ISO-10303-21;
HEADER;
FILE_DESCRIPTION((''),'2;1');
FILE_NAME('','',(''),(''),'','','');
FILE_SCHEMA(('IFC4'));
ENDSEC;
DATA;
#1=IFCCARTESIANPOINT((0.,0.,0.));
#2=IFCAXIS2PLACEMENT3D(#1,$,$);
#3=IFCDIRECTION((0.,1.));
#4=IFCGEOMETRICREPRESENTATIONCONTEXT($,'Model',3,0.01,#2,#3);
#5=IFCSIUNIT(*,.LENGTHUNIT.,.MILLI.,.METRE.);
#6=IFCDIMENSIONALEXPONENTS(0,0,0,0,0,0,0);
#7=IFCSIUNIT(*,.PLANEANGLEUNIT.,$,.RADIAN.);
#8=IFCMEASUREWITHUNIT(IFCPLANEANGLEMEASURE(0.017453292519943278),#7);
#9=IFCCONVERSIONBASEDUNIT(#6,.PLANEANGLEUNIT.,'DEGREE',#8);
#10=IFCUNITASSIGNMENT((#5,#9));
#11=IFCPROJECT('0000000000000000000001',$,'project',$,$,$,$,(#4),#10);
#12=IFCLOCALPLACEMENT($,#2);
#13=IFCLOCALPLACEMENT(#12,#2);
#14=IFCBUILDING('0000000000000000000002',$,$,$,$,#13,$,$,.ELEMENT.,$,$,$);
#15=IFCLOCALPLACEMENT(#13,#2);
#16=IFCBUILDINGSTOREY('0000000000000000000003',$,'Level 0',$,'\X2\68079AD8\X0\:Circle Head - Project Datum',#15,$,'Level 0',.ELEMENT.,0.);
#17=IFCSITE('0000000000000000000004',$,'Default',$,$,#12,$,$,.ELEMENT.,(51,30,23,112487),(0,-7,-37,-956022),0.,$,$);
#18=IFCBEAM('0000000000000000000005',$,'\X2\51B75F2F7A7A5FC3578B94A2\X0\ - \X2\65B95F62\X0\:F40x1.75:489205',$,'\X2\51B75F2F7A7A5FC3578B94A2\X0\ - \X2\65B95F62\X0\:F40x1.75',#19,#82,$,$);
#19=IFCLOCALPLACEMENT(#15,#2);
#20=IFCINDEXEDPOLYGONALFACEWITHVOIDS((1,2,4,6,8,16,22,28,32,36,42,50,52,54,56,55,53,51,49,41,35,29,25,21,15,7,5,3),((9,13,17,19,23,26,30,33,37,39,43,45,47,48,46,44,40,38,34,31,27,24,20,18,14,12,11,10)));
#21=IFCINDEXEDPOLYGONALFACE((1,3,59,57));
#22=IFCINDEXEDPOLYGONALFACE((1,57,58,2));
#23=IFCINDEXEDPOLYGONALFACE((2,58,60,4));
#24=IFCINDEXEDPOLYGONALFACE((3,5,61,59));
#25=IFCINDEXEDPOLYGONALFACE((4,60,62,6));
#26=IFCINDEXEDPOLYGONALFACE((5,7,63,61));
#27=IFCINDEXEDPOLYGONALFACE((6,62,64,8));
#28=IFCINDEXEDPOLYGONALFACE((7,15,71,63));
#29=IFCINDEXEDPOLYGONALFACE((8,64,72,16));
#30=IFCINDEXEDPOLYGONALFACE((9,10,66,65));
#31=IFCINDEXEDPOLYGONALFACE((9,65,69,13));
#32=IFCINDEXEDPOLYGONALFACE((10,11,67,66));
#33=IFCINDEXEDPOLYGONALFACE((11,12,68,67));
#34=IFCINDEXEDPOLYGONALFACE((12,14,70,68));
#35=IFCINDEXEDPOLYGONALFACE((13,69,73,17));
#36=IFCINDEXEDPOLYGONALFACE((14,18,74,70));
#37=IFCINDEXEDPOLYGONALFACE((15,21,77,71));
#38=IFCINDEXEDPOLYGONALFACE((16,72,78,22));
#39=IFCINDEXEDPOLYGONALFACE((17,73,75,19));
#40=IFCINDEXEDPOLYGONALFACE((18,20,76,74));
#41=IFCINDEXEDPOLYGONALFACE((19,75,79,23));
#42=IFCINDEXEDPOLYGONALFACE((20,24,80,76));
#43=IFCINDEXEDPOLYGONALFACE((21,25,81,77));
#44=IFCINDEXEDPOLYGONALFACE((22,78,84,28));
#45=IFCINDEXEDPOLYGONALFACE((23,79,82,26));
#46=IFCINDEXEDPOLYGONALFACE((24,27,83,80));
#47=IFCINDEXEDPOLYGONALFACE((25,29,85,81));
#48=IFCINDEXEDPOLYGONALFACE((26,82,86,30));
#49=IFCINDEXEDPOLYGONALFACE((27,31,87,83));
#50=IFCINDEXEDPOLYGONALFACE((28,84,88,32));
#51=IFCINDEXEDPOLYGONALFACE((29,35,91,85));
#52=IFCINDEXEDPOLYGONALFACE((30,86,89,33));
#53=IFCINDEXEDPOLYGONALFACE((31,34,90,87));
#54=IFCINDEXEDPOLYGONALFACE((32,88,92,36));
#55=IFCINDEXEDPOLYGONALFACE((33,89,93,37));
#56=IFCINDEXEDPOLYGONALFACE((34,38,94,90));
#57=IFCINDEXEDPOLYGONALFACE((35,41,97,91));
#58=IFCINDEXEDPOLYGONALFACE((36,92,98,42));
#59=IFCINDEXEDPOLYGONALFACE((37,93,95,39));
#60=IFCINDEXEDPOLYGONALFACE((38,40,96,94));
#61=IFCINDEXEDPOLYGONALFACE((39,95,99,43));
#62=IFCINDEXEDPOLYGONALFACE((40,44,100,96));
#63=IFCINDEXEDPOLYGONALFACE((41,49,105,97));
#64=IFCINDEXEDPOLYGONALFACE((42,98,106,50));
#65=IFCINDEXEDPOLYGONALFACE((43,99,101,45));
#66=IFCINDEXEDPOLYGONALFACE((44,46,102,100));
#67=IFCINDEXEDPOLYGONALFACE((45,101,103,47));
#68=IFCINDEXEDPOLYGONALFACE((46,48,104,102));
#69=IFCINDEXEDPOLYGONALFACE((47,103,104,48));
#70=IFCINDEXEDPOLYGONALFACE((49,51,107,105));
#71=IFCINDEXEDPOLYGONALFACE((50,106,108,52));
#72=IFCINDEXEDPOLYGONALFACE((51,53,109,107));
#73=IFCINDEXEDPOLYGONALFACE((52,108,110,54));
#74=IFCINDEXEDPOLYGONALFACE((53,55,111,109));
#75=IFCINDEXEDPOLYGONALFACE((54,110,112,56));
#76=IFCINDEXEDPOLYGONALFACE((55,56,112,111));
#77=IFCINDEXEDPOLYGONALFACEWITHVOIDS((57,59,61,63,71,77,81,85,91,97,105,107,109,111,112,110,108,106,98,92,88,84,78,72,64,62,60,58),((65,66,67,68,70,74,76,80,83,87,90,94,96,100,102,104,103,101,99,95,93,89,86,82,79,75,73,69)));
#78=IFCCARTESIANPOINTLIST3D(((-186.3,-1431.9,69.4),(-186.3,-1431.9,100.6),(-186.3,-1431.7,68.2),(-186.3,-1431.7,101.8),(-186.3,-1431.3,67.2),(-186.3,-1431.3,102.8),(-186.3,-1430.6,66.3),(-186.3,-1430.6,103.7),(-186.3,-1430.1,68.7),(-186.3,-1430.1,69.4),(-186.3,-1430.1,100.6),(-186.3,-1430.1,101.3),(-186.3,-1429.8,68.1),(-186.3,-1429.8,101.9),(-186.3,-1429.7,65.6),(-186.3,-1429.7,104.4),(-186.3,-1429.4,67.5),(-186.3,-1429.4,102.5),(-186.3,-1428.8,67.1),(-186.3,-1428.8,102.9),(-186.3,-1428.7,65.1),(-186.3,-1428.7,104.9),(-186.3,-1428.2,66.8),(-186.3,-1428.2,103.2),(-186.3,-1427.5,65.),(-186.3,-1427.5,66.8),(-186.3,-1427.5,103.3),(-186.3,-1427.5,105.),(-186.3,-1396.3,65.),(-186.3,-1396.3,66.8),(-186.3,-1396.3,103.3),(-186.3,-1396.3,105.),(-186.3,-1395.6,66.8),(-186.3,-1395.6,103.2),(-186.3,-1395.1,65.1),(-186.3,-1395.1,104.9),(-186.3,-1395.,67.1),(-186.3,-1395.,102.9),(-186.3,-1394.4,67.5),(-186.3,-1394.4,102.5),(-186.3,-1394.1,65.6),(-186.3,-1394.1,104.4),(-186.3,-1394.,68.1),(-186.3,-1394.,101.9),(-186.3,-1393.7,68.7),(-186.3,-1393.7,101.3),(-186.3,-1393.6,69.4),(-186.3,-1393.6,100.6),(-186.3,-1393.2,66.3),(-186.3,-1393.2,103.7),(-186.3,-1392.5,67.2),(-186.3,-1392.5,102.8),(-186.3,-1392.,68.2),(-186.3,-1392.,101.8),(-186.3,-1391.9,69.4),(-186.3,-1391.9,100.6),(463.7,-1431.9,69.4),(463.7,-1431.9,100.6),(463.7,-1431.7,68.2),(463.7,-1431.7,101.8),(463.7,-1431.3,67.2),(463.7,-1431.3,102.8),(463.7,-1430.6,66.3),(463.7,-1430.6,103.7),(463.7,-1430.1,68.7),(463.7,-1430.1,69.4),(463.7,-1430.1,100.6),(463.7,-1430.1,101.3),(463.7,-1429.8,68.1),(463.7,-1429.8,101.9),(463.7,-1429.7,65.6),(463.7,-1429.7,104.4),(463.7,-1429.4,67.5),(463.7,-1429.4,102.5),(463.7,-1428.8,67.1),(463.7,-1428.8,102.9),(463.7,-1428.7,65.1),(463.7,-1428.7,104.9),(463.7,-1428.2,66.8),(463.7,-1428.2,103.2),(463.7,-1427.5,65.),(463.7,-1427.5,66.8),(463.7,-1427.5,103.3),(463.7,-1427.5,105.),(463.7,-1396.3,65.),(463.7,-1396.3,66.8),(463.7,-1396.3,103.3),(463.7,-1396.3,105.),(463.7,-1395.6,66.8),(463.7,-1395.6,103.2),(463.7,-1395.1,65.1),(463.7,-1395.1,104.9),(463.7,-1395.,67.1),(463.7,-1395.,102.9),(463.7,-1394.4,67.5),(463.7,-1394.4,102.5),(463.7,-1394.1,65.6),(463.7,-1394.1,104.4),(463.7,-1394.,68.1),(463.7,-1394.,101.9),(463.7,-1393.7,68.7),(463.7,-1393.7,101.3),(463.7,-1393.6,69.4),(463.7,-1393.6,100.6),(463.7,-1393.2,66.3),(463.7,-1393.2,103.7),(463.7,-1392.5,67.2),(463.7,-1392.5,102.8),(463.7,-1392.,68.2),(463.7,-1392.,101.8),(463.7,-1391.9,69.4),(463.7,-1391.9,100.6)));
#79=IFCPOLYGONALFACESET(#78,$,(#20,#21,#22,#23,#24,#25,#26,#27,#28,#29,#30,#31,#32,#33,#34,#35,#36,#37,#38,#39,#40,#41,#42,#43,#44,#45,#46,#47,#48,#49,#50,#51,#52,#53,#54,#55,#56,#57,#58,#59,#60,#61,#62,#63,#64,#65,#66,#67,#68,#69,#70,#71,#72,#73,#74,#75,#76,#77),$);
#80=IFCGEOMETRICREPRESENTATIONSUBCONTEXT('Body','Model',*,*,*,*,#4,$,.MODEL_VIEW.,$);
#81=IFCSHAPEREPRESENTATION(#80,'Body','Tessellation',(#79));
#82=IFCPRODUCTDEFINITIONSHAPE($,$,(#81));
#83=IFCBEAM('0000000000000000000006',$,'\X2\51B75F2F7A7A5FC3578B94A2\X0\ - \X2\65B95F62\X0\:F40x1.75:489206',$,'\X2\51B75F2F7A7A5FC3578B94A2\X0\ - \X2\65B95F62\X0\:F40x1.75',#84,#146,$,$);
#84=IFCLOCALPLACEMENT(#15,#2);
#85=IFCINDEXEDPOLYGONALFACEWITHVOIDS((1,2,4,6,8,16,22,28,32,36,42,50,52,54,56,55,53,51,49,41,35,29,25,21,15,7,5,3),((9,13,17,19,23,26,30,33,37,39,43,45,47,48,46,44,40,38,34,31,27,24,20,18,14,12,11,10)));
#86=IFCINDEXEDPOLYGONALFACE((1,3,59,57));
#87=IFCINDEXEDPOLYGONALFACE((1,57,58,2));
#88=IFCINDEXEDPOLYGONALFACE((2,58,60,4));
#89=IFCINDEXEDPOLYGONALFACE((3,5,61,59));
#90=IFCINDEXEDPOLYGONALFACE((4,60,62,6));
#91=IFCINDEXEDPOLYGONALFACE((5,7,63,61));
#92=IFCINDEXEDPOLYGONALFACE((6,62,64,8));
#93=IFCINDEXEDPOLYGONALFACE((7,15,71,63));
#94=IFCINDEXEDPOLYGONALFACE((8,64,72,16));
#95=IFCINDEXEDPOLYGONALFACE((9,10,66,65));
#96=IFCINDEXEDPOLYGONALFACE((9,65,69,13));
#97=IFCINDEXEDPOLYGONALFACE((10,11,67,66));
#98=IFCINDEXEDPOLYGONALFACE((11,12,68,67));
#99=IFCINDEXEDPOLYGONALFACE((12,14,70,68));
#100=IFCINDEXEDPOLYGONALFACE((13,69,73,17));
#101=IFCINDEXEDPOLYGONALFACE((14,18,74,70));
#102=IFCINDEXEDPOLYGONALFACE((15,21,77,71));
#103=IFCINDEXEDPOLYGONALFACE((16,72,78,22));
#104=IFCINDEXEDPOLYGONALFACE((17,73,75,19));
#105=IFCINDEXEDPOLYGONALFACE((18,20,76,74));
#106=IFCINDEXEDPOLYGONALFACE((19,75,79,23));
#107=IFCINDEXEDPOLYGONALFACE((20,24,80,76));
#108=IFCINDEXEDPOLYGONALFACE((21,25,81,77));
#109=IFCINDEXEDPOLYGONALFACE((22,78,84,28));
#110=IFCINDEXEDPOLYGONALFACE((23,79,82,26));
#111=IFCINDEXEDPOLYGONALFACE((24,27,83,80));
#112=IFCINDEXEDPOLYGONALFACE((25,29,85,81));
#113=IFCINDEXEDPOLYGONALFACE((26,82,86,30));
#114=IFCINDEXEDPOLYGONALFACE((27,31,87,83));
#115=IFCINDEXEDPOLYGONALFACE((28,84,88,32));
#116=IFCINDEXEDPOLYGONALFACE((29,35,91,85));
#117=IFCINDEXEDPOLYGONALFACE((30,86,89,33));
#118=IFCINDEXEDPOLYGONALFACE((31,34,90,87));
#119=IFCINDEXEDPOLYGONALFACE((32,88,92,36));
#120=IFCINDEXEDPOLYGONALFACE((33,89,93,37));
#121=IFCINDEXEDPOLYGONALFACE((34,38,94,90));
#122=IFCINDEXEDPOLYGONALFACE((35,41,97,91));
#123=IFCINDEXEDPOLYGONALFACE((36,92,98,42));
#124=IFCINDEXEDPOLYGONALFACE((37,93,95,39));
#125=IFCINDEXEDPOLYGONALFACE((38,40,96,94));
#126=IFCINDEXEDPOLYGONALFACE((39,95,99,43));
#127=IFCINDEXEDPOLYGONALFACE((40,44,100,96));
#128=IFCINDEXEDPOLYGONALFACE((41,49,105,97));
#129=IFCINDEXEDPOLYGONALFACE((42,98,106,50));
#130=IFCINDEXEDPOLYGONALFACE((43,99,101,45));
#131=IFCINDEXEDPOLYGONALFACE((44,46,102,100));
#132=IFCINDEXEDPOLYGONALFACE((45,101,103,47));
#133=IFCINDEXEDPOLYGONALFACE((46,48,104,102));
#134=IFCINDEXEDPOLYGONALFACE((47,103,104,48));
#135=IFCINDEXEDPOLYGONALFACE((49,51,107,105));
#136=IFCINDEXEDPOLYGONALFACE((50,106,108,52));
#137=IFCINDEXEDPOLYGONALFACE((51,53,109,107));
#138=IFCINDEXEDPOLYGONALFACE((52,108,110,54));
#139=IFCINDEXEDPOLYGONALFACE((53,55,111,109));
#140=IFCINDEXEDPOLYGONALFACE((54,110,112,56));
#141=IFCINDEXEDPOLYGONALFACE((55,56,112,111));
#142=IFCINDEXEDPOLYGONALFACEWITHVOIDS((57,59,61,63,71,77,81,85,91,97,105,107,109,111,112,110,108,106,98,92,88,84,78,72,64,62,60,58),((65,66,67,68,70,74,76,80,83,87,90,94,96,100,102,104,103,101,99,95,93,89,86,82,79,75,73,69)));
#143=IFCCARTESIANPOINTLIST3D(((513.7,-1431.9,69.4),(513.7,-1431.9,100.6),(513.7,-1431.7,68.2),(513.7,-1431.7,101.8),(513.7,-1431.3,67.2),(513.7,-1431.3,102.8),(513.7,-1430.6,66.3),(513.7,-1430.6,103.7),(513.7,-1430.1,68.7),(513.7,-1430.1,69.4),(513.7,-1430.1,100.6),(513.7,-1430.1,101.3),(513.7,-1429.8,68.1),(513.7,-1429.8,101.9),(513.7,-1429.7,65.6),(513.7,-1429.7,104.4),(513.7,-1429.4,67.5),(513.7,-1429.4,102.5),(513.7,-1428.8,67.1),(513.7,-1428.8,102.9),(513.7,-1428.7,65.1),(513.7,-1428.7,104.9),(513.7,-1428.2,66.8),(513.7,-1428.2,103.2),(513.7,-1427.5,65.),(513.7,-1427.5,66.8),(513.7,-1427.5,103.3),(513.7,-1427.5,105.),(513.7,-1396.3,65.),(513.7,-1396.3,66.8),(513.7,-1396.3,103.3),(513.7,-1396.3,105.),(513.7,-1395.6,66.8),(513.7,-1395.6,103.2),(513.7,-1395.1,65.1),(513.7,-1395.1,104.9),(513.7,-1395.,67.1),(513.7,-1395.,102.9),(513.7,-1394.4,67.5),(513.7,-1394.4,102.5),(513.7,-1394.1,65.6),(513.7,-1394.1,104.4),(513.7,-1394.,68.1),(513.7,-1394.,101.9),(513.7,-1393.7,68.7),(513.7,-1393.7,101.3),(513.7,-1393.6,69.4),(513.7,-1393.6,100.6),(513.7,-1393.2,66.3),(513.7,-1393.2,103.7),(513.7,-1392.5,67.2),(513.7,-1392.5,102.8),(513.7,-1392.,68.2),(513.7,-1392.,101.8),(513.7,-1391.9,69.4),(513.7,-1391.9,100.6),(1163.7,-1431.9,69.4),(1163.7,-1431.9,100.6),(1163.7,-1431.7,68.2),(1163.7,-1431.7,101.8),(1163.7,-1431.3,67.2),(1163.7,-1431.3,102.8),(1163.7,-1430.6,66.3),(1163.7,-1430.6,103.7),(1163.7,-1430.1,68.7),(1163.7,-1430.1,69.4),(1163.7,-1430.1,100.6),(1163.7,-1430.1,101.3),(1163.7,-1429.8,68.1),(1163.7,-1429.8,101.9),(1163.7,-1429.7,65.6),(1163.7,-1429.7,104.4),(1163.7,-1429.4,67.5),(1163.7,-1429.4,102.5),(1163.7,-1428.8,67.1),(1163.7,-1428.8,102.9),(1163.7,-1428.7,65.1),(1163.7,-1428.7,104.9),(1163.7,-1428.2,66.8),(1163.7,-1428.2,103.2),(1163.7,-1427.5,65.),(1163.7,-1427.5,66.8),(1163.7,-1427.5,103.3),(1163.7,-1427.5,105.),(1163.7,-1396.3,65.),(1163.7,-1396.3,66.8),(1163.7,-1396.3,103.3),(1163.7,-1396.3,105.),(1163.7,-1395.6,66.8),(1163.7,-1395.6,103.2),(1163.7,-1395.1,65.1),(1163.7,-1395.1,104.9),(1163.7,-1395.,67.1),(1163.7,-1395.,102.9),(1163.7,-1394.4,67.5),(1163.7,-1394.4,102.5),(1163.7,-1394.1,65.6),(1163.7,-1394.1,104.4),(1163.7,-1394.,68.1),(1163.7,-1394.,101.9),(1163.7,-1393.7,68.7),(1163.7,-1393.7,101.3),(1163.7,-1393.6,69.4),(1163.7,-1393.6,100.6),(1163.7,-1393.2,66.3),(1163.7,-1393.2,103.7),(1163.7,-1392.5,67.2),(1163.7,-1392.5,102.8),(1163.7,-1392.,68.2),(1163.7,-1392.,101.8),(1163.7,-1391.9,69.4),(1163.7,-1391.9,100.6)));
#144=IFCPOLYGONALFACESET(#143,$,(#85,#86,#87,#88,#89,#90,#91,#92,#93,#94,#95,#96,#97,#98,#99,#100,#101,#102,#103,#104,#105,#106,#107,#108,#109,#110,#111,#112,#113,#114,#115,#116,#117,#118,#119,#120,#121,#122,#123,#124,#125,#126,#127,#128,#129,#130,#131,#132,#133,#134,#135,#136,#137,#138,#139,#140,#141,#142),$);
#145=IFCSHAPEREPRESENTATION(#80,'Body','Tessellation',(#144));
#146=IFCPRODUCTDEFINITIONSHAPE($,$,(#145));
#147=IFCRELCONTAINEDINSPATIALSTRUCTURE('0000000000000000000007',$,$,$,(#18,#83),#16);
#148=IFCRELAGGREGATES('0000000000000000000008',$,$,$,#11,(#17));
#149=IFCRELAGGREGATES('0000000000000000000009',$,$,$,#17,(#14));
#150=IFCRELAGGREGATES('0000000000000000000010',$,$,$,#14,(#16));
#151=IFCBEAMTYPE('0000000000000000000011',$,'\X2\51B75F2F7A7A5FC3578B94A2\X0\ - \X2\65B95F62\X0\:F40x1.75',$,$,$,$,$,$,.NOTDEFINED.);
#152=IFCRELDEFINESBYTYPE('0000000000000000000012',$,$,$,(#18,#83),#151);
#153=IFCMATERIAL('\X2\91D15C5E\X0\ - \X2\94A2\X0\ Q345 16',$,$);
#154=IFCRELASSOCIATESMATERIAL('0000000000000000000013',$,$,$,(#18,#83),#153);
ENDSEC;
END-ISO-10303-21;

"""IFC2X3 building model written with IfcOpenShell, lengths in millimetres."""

from ifc_helpers import new_model, entity, si_unit, converted_unit, direction, frame, frame_2d, origin, place, context, subcontext, project, spatial, polyline, circle_curve, parameter, trimmed, segment, composite_curve, outline, extrude, material, type_object, element, save


model = new_model("IFC2X3")

# Units and contexts
model_context = context("Model", 3, precision=0.01, world=origin(), true_north=direction((0.0, 1.0)))
body_context = subcontext(model_context, "Body", "Model", "MODEL_VIEW")
ifc_project = project(units=[si_unit("LENGTHUNIT", "METRE", prefix="MILLI"), converted_unit("PLANEANGLEUNIT", "DEGREE", entity("IfcPlaneAngleMeasure", 0.017453292519943278), si_unit("PLANEANGLEUNIT", "RADIAN"), dimensions=[0, 0, 0, 0, 0, 0, 0])], contexts=[model_context])

# Site, building, storey
site_placement = place(None, origin())
site = spatial("IfcSite", under=ifc_project, at=site_placement, Name="Default", CompositionType="ELEMENT", RefLatitude=(51, 30, 23, 112487), RefLongitude=(0, -7, -37, -956022), RefElevation=0.0)
building_placement = place(site_placement, origin())
building = spatial("IfcBuilding", under=site, at=building_placement, CompositionType="ELEMENT")
storey_placement = place(building_placement, origin())
storey = spatial("IfcBuildingStorey", under=building, at=storey_placement, Name="Level 0", ObjectType="标高:Circle Head - Project Datum", LongName="Level 0", CompositionType="ELEMENT", Elevation=0.0)

# Beams
ifc_material_1 = material(Name="金属 - 钢 Q345 16")
beam_type_1 = type_object("IfcBeamType", Name="冷弯空心型钢 - 方形:F40x1.75", PredefinedType="NOTDEFINED")
beam_1_placement = place(storey_placement, frame((-146.3, -1411.9, 105.0)))
element("IfcBeam", 1, at=beam_1_placement, inside=storey, type_object=beam_type_1, material=ifc_material_1, Name="冷弯空心型钢 - 方形:F40x1.75:489205", ObjectType="冷弯空心型钢 - 方形:F40x1.75", context=body_context, shape_type="SweptSolid", body=[
    extrude(outline(composite_curve([segment(trimmed(circle_curve(frame_2d((-15.6, 15.6), x_axis=(1.0, 0.0)), 4.4), [parameter(90.0)], [parameter(180.0)], True, "PARAMETER"), True, "CONTINUOUS"), segment(polyline([(-20.0, 15.6), (-20.0, -15.6)]), True, "CONTINUOUS"), segment(trimmed(circle_curve(frame_2d((-15.6, -15.6), x_axis=(1.0, 0.0)), 4.4), [parameter(180.0)], [parameter(270.0)], True, "PARAMETER"), True, "CONTINUOUS"), segment(polyline([(-15.6, -20.0), (15.6, -20.0)]), True, "CONTINUOUS"), segment(trimmed(circle_curve(frame_2d((15.6, -15.6), x_axis=(1.0, 0.0)), 4.4), [parameter(270.0)], [parameter(0.0)], True, "PARAMETER"), True, "CONTINUOUS"), segment(polyline([(20.0, -15.6), (20.0, 15.6)]), True, "CONTINUOUS"), segment(trimmed(circle_curve(frame_2d((15.6, 15.6), x_axis=(1.0, 0.0)), 4.4), [parameter(0.0)], [parameter(90.0)], True, "PARAMETER"), True, "CONTINUOUS"), segment(polyline([(15.6, 20.0), (-15.6, 20.0)]), True, "CONTINUOUS")], self_intersect=False), holes=[composite_curve([segment(polyline([(-15.6, 18.3), (15.6, 18.3)]), True, "CONTINUOUS"), segment(trimmed(circle_curve(frame_2d((15.6, 15.6), x_axis=(1.0, 0.0)), 2.6), [parameter(0.0)], [parameter(90.0)], True, "PARAMETER"), False, "CONTINUOUS"), segment(polyline([(18.2, 15.6), (18.2, -15.6)]), True, "CONTINUOUS"), segment(trimmed(circle_curve(frame_2d((15.6, -15.6), x_axis=(1.0, 0.0)), 2.6), [parameter(270.0)], [parameter(360.0)], True, "PARAMETER"), False, "CONTINUOUS"), segment(polyline([(15.6, -18.2), (-15.6, -18.2)]), True, "CONTINUOUS"), segment(trimmed(circle_curve(frame_2d((-15.6, -15.6), x_axis=(1.0, 0.0)), 2.6), [parameter(180.0)], [parameter(270.0)], True, "PARAMETER"), False, "CONTINUOUS"), segment(polyline([(-18.3, -15.6), (-18.3, 15.6)]), True, "CONTINUOUS"), segment(trimmed(circle_curve(frame_2d((-15.6, 15.6), x_axis=(1.0, 0.0)), 2.6), [parameter(90.0)], [parameter(180.0)], True, "PARAMETER"), False, "CONTINUOUS")], self_intersect=False)]), frame((-40.0, 0.0, -20.0), z_axis=(1.0, 0.0, 0.0), x_axis=(0.0, 1.0, 0.0)), (0.0, 0.0, 1.0), 650.0),
])
beam_2_placement = place(storey_placement, frame((583.7, -1411.9, 105.0)))
element("IfcBeam", 2, at=beam_2_placement, inside=storey, type_object=beam_type_1, material=ifc_material_1, Name="冷弯空心型钢 - 方形:F40x1.75:489206", ObjectType="冷弯空心型钢 - 方形:F40x1.75", context=body_context, shape_type="SweptSolid", body=[
    extrude(outline(composite_curve([segment(trimmed(circle_curve(frame_2d((-15.6, 15.6), x_axis=(1.0, 0.0)), 4.4), [parameter(90.0)], [parameter(180.0)], True, "PARAMETER"), True, "CONTINUOUS"), segment(polyline([(-20.0, 15.6), (-20.0, -15.6)]), True, "CONTINUOUS"), segment(trimmed(circle_curve(frame_2d((-15.6, -15.6), x_axis=(1.0, 0.0)), 4.4), [parameter(180.0)], [parameter(270.0)], True, "PARAMETER"), True, "CONTINUOUS"), segment(polyline([(-15.6, -20.0), (15.6, -20.0)]), True, "CONTINUOUS"), segment(trimmed(circle_curve(frame_2d((15.6, -15.6), x_axis=(1.0, 0.0)), 4.4), [parameter(270.0)], [parameter(0.0)], True, "PARAMETER"), True, "CONTINUOUS"), segment(polyline([(20.0, -15.6), (20.0, 15.6)]), True, "CONTINUOUS"), segment(trimmed(circle_curve(frame_2d((15.6, 15.6), x_axis=(1.0, 0.0)), 4.4), [parameter(0.0)], [parameter(90.0)], True, "PARAMETER"), True, "CONTINUOUS"), segment(polyline([(15.6, 20.0), (-15.6, 20.0)]), True, "CONTINUOUS")], self_intersect=False), holes=[composite_curve([segment(polyline([(-15.6, 18.3), (15.6, 18.3)]), True, "CONTINUOUS"), segment(trimmed(circle_curve(frame_2d((15.6, 15.6), x_axis=(1.0, 0.0)), 2.6), [parameter(0.0)], [parameter(90.0)], True, "PARAMETER"), False, "CONTINUOUS"), segment(polyline([(18.2, 15.6), (18.2, -15.6)]), True, "CONTINUOUS"), segment(trimmed(circle_curve(frame_2d((15.6, -15.6), x_axis=(1.0, 0.0)), 2.6), [parameter(270.0)], [parameter(360.0)], True, "PARAMETER"), False, "CONTINUOUS"), segment(polyline([(15.6, -18.2), (-15.6, -18.2)]), True, "CONTINUOUS"), segment(trimmed(circle_curve(frame_2d((-15.6, -15.6), x_axis=(1.0, 0.0)), 2.6), [parameter(180.0)], [parameter(270.0)], True, "PARAMETER"), False, "CONTINUOUS"), segment(polyline([(-18.3, -15.6), (-18.3, 15.6)]), True, "CONTINUOUS"), segment(trimmed(circle_curve(frame_2d((-15.6, 15.6), x_axis=(1.0, 0.0)), 2.6), [parameter(90.0)], [parameter(180.0)], True, "PARAMETER"), False, "CONTINUOUS")], self_intersect=False)]), frame((-70.0, 0.0, -20.0), z_axis=(1.0, 0.0, 0.0), x_axis=(0.0, 1.0, 0.0)), (0.0, 0.0, 1.0), 650.0),
])

save(model, "model.ifc")
